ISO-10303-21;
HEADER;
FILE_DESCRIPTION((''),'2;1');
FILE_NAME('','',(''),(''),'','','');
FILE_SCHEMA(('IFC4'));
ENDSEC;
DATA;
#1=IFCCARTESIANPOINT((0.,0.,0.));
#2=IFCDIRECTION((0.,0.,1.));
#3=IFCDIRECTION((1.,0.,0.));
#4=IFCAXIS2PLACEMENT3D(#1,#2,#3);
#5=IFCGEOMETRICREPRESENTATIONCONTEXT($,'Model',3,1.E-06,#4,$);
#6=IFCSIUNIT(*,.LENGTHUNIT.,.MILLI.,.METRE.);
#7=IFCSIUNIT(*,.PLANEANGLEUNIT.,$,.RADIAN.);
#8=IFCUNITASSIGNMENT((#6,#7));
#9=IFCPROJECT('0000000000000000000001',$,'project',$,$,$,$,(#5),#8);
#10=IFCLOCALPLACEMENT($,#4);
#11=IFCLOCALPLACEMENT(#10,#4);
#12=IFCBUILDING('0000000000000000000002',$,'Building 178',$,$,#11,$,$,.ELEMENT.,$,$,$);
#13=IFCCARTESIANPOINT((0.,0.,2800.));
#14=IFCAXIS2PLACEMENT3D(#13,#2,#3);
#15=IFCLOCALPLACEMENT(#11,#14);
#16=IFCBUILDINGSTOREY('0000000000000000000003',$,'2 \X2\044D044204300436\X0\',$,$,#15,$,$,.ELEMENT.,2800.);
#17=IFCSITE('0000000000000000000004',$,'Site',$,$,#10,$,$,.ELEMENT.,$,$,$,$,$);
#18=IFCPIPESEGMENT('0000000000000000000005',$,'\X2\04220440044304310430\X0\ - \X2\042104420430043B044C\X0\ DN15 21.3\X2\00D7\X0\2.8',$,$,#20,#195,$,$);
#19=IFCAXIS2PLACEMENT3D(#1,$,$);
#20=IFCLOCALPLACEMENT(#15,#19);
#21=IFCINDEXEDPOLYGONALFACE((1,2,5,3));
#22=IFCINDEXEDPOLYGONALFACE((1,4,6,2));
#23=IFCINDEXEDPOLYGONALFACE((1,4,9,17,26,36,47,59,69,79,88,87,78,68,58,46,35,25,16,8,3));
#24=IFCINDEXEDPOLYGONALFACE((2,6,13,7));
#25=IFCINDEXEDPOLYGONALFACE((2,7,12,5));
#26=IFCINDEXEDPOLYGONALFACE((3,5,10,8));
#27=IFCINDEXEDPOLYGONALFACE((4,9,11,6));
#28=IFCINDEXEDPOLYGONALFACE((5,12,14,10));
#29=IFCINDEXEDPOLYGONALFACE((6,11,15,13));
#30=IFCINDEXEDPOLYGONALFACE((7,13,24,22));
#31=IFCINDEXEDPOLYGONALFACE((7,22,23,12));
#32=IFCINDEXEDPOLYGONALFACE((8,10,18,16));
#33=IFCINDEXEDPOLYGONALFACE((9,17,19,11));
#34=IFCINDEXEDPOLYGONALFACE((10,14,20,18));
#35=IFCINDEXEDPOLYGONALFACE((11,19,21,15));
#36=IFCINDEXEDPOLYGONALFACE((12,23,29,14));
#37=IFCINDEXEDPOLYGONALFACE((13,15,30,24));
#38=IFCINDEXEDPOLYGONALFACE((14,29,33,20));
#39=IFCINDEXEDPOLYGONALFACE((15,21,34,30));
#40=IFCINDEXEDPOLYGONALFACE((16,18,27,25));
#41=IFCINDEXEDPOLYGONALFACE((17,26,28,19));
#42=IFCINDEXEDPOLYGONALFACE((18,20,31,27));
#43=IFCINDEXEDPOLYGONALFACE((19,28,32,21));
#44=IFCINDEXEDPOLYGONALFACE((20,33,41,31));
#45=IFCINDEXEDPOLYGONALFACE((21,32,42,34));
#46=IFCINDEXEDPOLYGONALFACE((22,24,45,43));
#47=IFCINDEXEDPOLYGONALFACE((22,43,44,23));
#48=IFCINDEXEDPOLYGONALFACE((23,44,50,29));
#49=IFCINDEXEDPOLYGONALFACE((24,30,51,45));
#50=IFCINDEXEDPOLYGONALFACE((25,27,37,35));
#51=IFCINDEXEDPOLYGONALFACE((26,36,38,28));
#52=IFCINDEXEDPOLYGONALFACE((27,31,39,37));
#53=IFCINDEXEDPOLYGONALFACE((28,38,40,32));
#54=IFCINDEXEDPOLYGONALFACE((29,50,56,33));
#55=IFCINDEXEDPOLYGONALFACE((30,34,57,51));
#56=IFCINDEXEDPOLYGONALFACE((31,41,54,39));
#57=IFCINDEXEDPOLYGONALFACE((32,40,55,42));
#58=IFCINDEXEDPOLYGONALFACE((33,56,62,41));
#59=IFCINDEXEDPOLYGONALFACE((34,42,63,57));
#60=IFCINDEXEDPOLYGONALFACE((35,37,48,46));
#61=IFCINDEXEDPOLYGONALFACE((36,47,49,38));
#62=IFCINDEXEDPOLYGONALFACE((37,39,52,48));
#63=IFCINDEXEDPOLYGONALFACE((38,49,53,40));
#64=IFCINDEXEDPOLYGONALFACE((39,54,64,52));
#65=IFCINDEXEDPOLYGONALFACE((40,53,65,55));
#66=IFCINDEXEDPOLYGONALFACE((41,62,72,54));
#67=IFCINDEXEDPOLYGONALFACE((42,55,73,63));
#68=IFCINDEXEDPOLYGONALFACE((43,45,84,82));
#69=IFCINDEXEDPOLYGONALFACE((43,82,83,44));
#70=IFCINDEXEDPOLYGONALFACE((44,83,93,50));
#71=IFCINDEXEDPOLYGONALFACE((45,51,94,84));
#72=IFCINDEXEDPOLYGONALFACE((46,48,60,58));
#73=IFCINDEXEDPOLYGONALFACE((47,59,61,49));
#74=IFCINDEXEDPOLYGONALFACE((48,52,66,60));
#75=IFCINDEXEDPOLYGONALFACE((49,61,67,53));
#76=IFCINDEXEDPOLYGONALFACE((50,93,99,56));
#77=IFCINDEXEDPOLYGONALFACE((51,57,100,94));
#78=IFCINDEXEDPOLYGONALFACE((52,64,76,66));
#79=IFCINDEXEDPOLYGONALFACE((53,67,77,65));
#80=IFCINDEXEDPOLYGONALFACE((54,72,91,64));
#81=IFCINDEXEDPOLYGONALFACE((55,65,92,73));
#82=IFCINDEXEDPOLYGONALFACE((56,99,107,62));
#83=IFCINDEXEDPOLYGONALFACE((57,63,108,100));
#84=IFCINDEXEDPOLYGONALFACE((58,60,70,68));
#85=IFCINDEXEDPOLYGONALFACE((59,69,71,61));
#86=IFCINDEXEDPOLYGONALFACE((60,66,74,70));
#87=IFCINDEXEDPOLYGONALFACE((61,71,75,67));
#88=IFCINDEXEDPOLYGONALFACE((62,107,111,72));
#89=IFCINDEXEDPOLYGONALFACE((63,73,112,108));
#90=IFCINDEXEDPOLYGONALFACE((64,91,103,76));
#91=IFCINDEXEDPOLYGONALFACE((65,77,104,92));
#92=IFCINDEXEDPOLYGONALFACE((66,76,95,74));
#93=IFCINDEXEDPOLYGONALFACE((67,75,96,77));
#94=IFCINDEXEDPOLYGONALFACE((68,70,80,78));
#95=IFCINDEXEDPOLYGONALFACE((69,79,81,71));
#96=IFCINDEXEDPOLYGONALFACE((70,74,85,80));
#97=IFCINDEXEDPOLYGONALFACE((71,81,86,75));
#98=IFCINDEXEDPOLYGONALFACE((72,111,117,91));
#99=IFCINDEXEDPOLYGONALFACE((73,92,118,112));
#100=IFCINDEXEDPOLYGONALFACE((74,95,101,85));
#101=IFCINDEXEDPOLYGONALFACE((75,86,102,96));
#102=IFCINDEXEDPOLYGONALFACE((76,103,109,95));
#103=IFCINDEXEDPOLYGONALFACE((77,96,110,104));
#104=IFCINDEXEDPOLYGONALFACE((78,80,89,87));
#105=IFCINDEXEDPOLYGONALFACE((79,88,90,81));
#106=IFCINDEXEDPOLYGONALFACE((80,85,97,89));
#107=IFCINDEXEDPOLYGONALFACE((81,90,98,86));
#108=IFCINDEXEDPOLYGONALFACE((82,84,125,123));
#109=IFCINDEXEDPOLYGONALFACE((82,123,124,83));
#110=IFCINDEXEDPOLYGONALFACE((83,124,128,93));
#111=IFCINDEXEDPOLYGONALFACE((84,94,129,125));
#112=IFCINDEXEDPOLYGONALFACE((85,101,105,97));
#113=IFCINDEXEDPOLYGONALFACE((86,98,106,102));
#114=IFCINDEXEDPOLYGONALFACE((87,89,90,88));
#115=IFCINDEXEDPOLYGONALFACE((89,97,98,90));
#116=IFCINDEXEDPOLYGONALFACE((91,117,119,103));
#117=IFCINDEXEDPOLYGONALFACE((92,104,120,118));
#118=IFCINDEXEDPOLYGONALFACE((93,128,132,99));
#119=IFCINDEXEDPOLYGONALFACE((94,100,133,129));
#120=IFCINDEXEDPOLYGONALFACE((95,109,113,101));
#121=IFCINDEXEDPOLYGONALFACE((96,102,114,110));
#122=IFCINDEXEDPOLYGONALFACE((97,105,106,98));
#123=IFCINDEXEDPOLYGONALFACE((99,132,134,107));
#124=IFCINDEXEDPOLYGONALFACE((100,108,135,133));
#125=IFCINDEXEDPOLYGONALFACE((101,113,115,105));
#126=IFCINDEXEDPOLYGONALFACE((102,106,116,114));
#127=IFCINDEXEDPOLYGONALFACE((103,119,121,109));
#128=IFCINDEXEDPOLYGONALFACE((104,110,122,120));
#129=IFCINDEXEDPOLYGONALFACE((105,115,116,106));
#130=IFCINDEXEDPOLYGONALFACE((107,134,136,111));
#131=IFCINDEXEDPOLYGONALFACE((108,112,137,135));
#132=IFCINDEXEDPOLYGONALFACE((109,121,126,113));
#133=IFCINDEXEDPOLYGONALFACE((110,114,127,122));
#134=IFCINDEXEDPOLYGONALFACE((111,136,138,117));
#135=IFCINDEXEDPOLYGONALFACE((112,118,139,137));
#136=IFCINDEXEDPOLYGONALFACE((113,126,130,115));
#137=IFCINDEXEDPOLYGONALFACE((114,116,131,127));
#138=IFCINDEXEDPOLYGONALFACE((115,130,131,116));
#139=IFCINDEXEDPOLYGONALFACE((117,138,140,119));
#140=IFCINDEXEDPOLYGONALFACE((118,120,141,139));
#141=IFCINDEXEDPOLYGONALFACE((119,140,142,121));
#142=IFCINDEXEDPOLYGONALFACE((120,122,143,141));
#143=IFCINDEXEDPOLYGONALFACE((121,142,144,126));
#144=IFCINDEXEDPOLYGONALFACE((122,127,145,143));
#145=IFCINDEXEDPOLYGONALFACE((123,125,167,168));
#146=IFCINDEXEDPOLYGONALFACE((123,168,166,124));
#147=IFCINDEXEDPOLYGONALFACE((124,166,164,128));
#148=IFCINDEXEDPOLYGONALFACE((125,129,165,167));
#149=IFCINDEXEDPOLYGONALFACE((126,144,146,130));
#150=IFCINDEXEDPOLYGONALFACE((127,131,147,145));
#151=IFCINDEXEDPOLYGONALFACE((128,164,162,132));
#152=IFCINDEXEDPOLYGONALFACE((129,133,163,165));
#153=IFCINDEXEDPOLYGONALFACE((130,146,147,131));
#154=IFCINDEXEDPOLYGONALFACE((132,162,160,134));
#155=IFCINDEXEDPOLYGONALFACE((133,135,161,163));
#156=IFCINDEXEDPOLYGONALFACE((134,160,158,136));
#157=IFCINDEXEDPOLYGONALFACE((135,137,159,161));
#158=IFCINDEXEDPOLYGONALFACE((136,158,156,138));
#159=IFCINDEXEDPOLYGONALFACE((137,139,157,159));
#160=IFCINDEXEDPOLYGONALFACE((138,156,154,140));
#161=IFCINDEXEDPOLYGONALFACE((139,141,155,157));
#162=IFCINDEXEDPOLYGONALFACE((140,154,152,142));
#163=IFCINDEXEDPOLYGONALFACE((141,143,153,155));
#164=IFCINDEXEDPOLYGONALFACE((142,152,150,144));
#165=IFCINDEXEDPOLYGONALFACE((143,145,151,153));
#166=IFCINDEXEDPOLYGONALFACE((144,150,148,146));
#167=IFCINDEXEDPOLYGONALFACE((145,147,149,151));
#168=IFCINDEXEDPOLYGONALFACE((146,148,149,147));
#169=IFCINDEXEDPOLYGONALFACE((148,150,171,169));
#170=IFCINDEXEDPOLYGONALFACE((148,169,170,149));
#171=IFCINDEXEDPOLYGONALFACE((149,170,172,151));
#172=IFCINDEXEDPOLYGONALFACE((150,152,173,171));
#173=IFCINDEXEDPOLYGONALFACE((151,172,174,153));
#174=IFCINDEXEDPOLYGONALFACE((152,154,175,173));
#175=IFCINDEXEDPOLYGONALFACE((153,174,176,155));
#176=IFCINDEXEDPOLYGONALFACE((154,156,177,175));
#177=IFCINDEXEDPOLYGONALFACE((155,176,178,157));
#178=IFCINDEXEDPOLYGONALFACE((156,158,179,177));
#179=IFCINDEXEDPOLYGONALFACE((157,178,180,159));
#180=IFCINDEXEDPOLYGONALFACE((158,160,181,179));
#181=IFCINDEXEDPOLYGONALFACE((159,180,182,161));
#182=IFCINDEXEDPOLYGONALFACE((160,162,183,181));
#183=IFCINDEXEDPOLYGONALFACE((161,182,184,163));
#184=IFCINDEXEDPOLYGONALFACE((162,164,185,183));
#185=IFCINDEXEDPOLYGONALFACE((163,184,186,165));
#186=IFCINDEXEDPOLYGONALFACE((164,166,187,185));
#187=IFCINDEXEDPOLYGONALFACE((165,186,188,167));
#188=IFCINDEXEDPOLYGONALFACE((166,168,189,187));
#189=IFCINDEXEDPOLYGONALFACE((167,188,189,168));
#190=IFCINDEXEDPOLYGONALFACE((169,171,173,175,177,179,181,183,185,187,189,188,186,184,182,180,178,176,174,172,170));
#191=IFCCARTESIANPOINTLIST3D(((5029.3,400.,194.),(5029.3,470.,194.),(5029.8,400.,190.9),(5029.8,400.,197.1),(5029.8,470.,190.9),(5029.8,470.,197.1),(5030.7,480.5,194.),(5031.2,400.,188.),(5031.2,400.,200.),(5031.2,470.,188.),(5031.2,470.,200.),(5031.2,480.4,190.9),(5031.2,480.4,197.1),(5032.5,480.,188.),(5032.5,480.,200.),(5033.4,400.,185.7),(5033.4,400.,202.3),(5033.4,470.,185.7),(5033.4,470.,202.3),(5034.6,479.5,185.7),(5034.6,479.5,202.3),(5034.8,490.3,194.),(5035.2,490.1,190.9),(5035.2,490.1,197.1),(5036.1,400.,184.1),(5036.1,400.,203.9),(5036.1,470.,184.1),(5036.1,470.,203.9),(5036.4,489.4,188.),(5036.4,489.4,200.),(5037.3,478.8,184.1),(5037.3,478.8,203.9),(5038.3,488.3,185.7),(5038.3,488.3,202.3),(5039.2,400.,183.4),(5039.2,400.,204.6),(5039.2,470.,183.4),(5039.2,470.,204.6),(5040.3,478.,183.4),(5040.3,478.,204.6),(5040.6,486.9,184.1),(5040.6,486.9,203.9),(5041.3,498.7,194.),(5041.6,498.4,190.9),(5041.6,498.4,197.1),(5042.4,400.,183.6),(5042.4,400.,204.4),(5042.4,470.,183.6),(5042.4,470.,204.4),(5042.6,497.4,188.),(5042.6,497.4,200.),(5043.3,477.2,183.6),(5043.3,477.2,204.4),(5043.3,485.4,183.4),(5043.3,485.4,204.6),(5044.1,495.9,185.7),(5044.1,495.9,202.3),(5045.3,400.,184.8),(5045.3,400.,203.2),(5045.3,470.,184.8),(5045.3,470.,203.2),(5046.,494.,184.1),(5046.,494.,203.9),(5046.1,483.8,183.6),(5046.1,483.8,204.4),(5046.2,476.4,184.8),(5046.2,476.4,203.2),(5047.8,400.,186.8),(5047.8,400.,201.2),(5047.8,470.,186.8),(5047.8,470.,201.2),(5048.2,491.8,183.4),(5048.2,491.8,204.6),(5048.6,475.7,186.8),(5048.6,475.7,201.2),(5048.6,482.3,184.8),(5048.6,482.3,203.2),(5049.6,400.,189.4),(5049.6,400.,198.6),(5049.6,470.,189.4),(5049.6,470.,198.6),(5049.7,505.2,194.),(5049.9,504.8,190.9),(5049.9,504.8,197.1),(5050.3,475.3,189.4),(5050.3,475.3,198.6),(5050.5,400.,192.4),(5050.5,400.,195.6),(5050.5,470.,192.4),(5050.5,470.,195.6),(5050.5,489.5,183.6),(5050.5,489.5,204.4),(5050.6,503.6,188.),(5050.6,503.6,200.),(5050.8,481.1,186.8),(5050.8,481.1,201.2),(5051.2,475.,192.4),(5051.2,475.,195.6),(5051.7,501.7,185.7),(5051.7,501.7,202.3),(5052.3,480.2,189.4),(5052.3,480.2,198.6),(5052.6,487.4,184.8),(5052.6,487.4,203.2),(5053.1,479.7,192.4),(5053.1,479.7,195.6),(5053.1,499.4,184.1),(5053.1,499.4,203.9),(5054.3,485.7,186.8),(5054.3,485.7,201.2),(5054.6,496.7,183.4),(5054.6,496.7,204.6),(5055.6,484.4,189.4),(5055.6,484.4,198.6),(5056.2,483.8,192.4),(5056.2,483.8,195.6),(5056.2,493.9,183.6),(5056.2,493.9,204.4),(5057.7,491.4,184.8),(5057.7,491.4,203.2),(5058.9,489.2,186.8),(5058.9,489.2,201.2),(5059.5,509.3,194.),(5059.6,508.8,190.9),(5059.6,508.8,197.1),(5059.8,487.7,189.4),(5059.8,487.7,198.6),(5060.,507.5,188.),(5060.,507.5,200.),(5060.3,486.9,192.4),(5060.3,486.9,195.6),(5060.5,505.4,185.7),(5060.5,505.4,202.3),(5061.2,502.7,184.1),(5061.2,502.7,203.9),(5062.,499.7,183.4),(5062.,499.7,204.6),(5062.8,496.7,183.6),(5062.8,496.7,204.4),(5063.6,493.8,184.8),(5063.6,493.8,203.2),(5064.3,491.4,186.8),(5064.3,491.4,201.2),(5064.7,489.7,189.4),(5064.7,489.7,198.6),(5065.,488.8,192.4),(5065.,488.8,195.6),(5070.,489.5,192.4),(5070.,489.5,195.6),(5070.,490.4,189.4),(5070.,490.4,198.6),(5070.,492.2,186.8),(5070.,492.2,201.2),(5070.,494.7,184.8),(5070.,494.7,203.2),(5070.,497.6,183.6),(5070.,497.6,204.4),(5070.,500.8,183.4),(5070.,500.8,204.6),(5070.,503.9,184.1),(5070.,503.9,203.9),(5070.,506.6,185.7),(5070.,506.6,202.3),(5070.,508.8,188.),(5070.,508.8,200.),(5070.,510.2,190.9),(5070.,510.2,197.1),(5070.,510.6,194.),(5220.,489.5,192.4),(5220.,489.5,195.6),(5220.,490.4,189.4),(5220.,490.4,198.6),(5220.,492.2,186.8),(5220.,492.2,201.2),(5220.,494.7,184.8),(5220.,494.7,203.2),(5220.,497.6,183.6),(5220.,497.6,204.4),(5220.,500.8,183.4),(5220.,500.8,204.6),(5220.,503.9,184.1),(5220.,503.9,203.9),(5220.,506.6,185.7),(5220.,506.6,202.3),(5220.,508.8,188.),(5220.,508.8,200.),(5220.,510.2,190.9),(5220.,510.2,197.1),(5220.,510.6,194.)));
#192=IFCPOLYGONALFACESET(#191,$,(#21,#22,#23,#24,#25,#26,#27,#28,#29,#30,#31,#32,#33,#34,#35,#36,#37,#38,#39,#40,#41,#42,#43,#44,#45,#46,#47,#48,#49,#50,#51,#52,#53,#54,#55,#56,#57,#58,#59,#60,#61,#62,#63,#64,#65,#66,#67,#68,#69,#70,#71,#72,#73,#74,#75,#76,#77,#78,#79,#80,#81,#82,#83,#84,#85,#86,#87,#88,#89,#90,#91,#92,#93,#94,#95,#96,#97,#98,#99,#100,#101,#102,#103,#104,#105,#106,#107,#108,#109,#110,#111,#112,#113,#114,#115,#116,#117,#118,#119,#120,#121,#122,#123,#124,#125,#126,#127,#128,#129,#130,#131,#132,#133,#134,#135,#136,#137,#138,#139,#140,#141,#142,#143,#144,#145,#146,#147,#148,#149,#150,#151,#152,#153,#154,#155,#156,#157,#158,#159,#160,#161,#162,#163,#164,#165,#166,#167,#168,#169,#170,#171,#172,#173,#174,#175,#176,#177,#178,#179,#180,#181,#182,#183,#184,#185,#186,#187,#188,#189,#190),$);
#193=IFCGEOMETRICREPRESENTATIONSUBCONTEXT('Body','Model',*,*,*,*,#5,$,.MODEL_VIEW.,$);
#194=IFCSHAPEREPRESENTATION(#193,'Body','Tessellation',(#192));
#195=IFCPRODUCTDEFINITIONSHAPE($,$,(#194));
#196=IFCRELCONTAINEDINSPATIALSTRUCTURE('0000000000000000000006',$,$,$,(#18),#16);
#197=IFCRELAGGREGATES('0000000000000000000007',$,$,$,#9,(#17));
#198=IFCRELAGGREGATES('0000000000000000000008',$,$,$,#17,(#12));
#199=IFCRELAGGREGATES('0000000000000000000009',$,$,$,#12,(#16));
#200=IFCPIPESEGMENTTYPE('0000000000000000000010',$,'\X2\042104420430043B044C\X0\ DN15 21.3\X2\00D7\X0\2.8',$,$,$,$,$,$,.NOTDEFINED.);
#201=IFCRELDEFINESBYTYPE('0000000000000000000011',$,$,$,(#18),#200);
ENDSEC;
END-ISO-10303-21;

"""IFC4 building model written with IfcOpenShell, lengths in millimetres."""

from ifc_helpers import new_model, entity, si_unit, frame, origin_with_axes, place, context, subcontext, project, spatial, source, transform, mapped, type_object, element, save


model = new_model("IFC4")

# Units and contexts
model_context = context("Model", 3, precision=1e-06, world=origin_with_axes())
body_context = subcontext(model_context, "Body", "Model", "MODEL_VIEW")
ifc_project = project(units=[si_unit("LENGTHUNIT", "METRE", prefix="MILLI"), si_unit("PLANEANGLEUNIT", "RADIAN")], contexts=[model_context])

# Site, building, storey
site_placement = place(None, origin_with_axes())
site = spatial("IfcSite", under=ifc_project, at=site_placement, Name="Site", CompositionType="ELEMENT")
building_placement = place(site_placement, origin_with_axes())
building = spatial("IfcBuilding", under=site, at=building_placement, Name="Building 178", CompositionType="ELEMENT")
storey_placement = place(building_placement, frame((0.0, 0.0, 2800.0), z_axis=(0.0, 0.0, 1.0), x_axis=(1.0, 0.0, 0.0)))
storey = spatial("IfcBuildingStorey", under=building, at=storey_placement, Name="2 этаж", CompositionType="ELEMENT", Elevation=2800.0)

# Pipe segment
pipe_segment_type = type_object("IfcPipeSegmentType", Name="Сталь DN15 21.3×2.8", PredefinedType="NOTDEFINED")
shared_shape_1 = source(origin_with_axes(), body_context, "Body", "AdvancedSweptSolid", [
    entity("IfcSweptDiskSolid", entity("IfcIndexedPolyCurve", entity("IfcCartesianPointList3D", [[0.0, 0.0, 0.0], [0.0, 0.0, -70.0], [8.8, 0.0, -91.2], [30.0, 0.0, -100.0], [180.0, 0.0, -100.0]]), [entity("IfcLineIndex", [1, 2]), entity("IfcArcIndex", [2, 3, 4]), entity("IfcLineIndex", [4, 5])]), 10.7),
])
for number, where, z_axis, x_axis, name in (
    (1, (5040.0, 400.0, 194.0), (0.0, -1.0, 0.0), (1.0, 0.0, 0.0), "Труба - Сталь DN15 21.3×2.8"),
):
    element("IfcPipeSegment", number, at=place(storey_placement, frame(where, z_axis=z_axis, x_axis=x_axis)), inside=storey, type_object=pipe_segment_type, Name=name, context=body_context, shape_type="MappedRepresentation", body=[
        mapped(shared_shape_1, transform((0.0, 0.0, 0.0), x_axis=(1.0, 0.0, 0.0), y_axis=(0.0, 1.0, 0.0), z_axis=(0.0, 0.0, 1.0), scale=1.0)),
    ])

save(model, "model.ifc")
